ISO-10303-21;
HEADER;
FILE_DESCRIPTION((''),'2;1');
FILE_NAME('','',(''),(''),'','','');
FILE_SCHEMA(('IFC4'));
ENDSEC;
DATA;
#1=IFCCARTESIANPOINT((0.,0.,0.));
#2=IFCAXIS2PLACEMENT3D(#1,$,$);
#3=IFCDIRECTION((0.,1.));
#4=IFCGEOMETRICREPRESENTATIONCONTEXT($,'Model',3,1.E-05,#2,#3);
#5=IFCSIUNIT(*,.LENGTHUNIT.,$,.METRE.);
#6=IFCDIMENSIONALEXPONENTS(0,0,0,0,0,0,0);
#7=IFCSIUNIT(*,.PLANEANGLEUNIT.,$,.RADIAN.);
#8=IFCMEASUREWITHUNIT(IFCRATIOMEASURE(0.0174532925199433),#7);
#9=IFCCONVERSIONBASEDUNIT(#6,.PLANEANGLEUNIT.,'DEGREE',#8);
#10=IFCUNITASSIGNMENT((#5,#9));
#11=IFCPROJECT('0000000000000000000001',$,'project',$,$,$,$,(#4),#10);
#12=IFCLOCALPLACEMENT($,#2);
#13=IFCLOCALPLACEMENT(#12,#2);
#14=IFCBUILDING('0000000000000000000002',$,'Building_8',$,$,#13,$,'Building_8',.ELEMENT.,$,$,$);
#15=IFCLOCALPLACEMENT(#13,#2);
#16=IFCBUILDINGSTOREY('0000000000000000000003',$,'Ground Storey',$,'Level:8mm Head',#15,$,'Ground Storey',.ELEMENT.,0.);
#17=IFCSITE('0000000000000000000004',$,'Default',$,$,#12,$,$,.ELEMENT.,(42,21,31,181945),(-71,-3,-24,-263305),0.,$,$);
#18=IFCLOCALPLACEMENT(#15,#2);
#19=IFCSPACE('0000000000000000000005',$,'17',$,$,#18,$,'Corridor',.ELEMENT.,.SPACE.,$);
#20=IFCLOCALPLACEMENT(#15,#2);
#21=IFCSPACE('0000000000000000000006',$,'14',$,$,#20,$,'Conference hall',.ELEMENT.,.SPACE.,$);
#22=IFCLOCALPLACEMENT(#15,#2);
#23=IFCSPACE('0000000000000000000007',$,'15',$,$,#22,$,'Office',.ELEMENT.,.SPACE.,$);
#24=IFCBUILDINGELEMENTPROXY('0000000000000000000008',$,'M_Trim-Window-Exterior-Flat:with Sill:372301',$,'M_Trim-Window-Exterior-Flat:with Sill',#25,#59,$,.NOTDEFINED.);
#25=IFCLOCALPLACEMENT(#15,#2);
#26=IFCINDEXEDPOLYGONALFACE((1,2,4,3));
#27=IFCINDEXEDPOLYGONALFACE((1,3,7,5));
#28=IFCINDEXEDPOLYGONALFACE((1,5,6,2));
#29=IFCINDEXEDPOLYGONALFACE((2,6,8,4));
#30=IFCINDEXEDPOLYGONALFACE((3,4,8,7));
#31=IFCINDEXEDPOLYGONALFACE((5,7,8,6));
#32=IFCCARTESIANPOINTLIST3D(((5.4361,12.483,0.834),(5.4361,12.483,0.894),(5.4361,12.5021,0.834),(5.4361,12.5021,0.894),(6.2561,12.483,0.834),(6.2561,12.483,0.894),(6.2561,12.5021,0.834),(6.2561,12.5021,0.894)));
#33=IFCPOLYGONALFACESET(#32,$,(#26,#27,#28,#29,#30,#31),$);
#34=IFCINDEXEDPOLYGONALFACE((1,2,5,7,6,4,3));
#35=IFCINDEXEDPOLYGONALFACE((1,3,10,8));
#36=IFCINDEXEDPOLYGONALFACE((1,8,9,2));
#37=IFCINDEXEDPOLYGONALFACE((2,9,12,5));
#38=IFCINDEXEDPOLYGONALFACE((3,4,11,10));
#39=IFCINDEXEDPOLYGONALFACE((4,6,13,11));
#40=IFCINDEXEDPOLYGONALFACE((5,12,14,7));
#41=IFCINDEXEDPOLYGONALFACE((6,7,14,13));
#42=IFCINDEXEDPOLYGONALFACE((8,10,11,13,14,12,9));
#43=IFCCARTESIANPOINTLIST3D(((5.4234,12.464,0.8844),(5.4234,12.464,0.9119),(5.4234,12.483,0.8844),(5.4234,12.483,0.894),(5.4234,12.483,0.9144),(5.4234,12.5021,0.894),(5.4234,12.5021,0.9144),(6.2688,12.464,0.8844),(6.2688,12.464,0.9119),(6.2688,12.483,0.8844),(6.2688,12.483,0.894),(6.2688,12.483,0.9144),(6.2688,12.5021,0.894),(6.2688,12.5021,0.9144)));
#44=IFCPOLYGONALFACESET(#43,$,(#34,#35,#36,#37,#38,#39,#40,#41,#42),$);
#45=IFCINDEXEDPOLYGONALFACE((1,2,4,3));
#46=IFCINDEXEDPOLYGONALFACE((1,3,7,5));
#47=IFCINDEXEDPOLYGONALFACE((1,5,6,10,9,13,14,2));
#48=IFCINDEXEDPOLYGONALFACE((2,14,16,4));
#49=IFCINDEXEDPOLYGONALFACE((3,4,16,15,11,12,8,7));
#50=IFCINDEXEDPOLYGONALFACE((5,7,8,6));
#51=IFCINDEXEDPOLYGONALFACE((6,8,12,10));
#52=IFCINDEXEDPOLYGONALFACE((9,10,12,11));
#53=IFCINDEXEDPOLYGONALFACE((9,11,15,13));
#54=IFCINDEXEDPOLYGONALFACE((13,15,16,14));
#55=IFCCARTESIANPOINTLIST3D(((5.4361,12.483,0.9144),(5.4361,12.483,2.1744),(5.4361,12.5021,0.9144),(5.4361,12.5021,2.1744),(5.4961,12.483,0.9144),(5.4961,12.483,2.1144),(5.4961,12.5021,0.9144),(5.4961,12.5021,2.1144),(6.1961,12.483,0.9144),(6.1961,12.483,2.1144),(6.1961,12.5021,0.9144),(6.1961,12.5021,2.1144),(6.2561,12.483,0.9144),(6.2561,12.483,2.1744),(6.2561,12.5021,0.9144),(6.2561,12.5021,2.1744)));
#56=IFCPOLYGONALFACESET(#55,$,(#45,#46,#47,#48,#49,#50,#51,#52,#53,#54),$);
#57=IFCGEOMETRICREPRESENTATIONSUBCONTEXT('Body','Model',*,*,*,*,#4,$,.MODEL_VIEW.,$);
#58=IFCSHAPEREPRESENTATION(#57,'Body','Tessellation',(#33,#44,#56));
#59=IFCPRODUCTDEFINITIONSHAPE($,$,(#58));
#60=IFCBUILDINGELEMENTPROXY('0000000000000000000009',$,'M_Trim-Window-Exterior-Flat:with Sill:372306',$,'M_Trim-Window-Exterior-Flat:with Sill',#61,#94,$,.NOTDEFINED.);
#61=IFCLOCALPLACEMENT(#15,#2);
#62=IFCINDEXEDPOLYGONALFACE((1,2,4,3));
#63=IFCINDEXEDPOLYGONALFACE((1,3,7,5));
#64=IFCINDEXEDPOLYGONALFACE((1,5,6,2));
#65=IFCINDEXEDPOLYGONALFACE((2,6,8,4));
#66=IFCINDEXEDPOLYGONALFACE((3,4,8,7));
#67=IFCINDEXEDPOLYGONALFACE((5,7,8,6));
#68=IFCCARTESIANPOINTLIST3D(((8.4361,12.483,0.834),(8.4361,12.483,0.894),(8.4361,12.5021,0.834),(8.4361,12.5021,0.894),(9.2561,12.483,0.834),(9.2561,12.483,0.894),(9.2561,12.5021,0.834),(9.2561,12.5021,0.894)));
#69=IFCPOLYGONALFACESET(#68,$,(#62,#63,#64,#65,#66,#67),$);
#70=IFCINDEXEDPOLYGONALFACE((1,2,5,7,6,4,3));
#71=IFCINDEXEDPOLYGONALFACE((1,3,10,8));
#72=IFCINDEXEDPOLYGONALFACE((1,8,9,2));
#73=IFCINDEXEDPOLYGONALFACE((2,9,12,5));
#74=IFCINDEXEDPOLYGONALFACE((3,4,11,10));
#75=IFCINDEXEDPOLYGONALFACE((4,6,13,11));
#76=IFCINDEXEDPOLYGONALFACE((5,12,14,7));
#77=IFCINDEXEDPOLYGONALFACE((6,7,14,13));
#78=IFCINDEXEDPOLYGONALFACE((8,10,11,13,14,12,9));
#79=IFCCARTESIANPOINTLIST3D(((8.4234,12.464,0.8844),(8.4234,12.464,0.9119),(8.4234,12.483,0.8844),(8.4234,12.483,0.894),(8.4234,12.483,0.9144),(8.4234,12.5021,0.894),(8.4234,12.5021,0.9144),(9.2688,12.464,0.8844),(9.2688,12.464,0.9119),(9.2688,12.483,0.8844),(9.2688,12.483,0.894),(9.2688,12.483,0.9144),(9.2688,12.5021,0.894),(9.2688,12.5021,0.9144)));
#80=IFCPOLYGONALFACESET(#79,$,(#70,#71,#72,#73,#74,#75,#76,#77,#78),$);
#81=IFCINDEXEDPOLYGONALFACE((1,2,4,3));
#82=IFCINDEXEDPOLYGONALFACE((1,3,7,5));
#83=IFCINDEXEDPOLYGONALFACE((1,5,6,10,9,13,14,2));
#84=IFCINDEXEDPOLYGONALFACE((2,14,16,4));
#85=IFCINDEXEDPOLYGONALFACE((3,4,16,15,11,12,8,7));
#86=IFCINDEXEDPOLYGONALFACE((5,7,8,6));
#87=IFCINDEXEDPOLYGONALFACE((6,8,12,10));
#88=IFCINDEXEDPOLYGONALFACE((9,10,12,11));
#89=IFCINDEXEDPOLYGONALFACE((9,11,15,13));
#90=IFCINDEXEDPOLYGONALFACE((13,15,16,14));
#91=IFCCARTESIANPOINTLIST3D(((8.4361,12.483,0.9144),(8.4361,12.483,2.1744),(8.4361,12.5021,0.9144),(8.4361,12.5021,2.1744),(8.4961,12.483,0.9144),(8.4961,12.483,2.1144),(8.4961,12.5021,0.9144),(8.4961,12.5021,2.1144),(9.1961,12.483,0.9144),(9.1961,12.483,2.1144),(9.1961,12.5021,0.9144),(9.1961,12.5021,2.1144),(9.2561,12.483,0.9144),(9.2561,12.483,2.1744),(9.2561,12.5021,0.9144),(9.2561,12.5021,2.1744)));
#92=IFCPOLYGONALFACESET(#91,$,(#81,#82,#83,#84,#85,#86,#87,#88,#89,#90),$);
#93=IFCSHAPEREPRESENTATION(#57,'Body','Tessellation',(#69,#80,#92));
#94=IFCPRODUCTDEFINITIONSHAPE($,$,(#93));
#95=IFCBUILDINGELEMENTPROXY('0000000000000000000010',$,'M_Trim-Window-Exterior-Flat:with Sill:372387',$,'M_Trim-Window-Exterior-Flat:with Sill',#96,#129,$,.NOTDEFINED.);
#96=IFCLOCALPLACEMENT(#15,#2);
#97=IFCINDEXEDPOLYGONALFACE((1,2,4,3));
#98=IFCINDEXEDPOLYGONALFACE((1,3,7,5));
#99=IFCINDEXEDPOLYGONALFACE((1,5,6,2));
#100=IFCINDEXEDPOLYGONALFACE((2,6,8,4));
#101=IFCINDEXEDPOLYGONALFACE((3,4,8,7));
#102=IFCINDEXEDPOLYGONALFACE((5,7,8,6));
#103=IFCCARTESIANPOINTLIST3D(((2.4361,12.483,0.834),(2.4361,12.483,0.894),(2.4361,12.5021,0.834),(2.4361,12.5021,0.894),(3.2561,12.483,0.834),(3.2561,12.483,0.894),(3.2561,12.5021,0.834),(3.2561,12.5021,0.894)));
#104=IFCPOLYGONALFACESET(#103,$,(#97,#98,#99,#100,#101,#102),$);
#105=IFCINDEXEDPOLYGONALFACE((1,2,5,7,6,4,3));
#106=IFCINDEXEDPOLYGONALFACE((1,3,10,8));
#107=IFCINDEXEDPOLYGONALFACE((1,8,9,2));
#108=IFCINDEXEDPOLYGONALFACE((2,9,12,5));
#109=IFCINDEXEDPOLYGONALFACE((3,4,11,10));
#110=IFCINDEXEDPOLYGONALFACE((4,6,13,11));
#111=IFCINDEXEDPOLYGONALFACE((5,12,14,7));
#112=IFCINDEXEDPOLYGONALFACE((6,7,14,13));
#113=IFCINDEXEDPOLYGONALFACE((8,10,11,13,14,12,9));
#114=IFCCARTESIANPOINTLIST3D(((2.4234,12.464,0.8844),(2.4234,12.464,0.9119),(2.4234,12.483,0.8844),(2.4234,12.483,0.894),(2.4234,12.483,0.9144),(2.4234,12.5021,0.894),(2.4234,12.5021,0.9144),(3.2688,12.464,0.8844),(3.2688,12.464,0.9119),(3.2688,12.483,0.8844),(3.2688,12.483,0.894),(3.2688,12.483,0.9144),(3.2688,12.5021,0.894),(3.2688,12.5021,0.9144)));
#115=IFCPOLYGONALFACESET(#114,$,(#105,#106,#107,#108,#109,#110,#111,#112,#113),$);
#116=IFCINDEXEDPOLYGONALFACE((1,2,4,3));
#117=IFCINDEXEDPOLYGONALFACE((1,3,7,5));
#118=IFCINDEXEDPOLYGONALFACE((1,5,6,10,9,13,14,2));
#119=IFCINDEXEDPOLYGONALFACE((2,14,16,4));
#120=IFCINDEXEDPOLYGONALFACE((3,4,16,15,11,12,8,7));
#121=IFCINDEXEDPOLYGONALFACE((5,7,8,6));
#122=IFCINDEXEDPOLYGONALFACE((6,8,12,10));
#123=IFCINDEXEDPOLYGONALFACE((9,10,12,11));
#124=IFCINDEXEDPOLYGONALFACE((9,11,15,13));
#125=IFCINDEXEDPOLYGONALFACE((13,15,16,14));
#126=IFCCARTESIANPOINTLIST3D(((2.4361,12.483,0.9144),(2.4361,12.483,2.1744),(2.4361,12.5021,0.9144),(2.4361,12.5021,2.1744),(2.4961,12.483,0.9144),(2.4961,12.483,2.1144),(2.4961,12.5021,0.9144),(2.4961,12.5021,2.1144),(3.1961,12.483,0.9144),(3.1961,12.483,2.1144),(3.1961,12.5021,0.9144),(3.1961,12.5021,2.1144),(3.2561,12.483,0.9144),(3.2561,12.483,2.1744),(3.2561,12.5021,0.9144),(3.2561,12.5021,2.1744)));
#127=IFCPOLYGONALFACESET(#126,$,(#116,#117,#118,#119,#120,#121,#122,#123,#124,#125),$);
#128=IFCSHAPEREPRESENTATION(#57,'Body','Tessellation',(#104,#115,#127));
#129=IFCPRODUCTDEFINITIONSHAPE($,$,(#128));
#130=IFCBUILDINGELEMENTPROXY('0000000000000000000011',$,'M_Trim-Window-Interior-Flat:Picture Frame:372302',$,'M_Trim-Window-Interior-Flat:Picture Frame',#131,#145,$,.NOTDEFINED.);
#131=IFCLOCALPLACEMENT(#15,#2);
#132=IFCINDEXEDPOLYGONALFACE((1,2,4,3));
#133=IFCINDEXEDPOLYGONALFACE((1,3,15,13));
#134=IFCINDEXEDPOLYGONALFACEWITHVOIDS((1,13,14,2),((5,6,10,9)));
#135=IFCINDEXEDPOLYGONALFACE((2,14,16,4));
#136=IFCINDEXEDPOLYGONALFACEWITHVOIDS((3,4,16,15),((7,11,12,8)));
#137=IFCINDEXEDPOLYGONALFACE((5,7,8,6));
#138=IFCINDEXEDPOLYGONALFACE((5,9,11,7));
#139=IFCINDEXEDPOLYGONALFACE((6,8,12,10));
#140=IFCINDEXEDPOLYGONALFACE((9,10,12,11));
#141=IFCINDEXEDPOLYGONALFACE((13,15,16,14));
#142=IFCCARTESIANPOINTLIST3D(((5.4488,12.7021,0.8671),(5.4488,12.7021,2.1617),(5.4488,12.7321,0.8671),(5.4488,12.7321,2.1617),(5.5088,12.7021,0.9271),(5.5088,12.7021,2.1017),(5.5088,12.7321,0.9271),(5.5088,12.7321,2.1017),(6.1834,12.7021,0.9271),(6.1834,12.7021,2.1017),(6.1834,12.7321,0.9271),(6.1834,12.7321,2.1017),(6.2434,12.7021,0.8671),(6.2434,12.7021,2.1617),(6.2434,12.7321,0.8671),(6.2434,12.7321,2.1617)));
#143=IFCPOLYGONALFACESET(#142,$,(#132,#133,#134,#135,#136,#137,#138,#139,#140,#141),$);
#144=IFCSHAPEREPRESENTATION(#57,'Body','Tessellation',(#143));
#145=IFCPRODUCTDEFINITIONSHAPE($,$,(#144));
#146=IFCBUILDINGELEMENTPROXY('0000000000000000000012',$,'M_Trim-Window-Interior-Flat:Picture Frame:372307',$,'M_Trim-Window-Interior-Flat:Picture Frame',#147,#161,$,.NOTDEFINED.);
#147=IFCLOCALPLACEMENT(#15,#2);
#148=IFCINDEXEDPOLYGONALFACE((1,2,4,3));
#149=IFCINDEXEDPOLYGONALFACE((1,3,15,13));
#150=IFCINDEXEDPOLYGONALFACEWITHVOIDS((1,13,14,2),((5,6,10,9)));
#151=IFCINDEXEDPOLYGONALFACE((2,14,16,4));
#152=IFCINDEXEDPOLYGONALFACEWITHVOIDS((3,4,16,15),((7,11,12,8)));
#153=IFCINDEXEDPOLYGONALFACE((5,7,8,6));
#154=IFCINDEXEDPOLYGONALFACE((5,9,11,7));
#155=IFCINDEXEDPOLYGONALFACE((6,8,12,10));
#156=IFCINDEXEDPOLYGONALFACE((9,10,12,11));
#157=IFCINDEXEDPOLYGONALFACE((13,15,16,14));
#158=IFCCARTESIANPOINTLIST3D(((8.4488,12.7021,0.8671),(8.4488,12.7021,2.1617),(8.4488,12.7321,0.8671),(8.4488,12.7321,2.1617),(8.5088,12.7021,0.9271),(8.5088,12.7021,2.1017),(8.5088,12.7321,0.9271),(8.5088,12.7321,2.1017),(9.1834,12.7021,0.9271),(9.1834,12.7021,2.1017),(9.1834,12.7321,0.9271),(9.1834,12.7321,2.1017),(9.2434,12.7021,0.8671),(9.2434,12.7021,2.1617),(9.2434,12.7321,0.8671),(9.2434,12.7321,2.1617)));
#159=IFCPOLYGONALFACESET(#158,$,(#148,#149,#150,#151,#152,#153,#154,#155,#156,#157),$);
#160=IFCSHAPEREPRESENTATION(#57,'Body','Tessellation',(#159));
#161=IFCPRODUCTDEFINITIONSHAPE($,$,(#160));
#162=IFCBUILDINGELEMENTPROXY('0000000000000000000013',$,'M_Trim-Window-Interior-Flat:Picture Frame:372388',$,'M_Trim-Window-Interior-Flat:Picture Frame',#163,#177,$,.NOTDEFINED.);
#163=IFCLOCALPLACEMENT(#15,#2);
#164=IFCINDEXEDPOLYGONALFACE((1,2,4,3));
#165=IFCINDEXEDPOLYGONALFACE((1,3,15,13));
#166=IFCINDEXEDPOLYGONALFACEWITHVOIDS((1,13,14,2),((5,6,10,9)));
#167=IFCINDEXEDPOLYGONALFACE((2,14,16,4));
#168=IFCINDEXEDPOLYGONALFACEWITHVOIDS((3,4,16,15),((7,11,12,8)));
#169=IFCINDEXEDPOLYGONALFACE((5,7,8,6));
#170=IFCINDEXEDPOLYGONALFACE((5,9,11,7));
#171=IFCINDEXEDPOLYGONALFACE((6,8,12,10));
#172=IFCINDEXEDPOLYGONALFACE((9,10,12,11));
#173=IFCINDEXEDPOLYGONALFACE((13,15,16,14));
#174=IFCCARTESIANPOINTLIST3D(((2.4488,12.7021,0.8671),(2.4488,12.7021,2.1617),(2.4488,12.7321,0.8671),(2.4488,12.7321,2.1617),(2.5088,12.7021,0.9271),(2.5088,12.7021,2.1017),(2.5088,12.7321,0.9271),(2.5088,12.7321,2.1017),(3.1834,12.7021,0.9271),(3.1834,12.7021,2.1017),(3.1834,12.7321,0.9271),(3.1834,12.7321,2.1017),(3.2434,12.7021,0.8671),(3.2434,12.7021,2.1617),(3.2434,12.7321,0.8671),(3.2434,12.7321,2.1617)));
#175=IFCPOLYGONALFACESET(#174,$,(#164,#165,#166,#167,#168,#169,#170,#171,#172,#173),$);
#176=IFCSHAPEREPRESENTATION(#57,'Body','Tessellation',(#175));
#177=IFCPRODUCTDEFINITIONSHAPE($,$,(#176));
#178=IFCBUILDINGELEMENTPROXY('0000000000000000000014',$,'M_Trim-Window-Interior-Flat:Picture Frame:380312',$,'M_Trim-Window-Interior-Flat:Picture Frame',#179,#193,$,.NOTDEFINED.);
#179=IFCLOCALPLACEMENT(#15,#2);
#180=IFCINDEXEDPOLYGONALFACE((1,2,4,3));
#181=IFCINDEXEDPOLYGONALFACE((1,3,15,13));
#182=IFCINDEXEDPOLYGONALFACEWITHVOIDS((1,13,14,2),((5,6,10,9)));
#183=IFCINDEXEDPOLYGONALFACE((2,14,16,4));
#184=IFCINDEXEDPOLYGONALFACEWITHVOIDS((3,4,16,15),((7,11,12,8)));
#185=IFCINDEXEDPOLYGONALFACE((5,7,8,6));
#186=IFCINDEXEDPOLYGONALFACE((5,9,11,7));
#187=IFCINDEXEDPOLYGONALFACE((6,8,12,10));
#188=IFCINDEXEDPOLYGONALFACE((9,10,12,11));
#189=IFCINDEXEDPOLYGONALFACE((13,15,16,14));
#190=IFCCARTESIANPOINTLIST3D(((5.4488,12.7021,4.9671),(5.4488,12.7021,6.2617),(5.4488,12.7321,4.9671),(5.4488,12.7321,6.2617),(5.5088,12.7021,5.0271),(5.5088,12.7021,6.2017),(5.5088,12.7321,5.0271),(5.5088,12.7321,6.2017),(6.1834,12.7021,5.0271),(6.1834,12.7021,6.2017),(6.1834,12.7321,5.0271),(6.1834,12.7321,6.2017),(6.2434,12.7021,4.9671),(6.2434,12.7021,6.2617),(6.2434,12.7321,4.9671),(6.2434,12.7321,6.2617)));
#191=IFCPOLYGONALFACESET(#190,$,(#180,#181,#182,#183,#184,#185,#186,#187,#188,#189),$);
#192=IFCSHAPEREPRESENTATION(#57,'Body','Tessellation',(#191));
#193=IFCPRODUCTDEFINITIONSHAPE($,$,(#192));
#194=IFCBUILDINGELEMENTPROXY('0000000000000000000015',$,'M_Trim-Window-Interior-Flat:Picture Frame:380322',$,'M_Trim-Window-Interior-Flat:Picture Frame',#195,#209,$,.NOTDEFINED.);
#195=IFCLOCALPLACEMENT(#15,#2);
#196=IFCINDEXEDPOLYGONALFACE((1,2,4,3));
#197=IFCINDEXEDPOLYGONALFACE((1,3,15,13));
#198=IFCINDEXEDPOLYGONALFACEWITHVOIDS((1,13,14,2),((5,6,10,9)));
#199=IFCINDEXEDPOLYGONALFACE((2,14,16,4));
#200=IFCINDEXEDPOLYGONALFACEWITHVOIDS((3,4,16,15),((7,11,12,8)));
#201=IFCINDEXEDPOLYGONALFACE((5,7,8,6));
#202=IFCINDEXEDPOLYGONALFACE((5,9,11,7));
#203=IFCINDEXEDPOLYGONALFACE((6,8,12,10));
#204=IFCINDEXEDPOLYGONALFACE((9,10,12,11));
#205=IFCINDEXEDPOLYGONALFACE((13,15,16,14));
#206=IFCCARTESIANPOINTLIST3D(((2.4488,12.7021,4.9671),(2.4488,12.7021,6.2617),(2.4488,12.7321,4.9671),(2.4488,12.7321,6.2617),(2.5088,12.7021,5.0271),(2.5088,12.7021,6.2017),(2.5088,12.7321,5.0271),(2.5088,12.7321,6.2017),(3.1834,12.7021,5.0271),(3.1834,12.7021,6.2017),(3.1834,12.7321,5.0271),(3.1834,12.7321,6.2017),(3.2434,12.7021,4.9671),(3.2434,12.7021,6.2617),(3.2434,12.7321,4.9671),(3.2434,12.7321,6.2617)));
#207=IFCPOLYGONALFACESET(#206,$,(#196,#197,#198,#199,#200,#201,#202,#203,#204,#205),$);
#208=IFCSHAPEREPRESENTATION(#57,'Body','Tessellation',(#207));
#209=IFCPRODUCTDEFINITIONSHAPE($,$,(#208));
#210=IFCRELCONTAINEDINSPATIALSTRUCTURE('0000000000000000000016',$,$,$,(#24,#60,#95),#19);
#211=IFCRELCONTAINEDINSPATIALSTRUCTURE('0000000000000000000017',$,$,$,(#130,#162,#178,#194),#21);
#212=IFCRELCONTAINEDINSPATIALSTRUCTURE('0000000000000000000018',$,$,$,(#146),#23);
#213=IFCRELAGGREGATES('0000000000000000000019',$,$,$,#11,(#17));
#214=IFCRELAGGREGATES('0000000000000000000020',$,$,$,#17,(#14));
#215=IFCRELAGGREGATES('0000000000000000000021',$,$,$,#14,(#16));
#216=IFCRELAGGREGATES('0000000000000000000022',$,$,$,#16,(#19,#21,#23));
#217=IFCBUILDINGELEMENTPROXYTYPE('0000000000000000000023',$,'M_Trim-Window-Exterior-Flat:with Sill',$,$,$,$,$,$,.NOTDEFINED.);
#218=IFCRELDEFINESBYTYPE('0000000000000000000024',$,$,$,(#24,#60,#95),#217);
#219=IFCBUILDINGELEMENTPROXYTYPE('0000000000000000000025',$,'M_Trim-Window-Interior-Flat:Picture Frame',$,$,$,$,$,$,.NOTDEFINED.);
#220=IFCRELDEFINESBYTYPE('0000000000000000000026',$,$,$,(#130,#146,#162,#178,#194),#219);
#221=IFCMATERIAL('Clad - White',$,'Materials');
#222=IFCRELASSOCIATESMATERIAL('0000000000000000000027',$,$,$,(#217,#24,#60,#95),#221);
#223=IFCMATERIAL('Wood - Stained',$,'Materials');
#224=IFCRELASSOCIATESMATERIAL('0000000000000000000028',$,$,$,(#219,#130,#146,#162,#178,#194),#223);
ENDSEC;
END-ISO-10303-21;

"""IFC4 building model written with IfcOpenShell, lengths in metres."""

from ifc_helpers import new_model, entity, si_unit, converted_unit, direction, frame, origin, place, context, subcontext, project, spatial, indexed_curve, outline, extrude, source, transform, mapped, material, type_object, type_shapes, element, save


model = new_model("IFC4")

# Units and contexts
model_context = context("Model", 3, precision=1e-05, world=origin(), true_north=direction((0.0, 1.0)))
body_context = subcontext(model_context, "Body", "Model", "MODEL_VIEW")
ifc_project = project(units=[si_unit("LENGTHUNIT", "METRE"), converted_unit("PLANEANGLEUNIT", "DEGREE", entity("IfcRatioMeasure", 0.0174532925199433), si_unit("PLANEANGLEUNIT", "RADIAN"), dimensions=[0, 0, 0, 0, 0, 0, 0])], contexts=[model_context])

# Site, building, storey
site_placement = place(None, origin())
site = spatial("IfcSite", under=ifc_project, at=site_placement, Name="Default", CompositionType="ELEMENT", RefLatitude=(42, 21, 31, 181945), RefLongitude=(-71, -3, -24, -263305), RefElevation=0.0)
building_placement = place(site_placement, origin())
building = spatial("IfcBuilding", under=site, at=building_placement, Name="Building_8", LongName="Building_8", CompositionType="ELEMENT")
storey_placement = place(building_placement, origin())
storey = spatial("IfcBuildingStorey", under=building, at=storey_placement, Name="Ground Storey", ObjectType="Level:8mm Head", LongName="Ground Storey", CompositionType="ELEMENT", Elevation=0.0)

# Shared definitions
ifc_material_1 = material(Name="Clad - White", Category="Materials")
ifc_material_2 = material(Name="Wood - Stained", Category="Materials")

# Shared definitions
space_1_placement = place(storey_placement, origin())
space_1 = spatial("IfcSpace", under=storey, at=space_1_placement, Name="17", LongName="Corridor", CompositionType="ELEMENT", PredefinedType="SPACE")

# Building element proxies
building_element_proxy_type_1 = type_object("IfcBuildingElementProxyType", Name="M_Trim-Window-Exterior-Flat:with Sill", PredefinedType="NOTDEFINED", material=ifc_material_1)
shared_shape_1 = source(origin(), body_context, "Body", "SweptSolid", [
    extrude(outline(indexed_curve([(-0.03, -0.41), (0.03, -0.41), (0.03, 0.41), (-0.03, 0.41), (-0.03, -0.41)], self_intersect=False)), frame((0.0, 1.2504, 0.0), z_axis=(0.0, 0.0, 1.0), x_axis=(0.0, 1.0, 0.0)), (0.0, 0.0, 1.0), 0.0191),
    extrude(outline(indexed_curve([(-0.0152, -0.019), (0.0123, -0.019), (0.0148, 0.0), (0.0148, 0.019), (-0.0057, 0.019), (-0.0057, 0.0), (-0.0152, 0.0), (-0.0152, -0.019)], self_intersect=False)), frame((-0.4227, 1.2148, 0.019), z_axis=(1.0, 0.0, 0.0), x_axis=(0.0, -1.0, 0.0)), (0.0, 0.0, 1.0), 0.8454),
    extrude(outline(indexed_curve([(-0.41, -0.645), (0.41, -0.645), (0.41, 0.615), (0.35, 0.615), (0.35, -0.585), (-0.35, -0.585), (-0.35, 0.615), (-0.41, 0.615), (-0.41, -0.645)], self_intersect=False)), frame((0.0, 0.585, 0.0)), (0.0, 0.0, 1.0), 0.0191),
])
type_shapes(building_element_proxy_type_1, [shared_shape_1])
for number, where, z_axis, x_axis, name in (
    (1, (5.8461, 12.5021, 2.1144), (0.0, -1.0, 0.0), (-1.0, 0.0, 0.0), "M_Trim-Window-Exterior-Flat:with Sill:372301"),
    (2, (8.8461, 12.5021, 2.1144), (0.0, -1.0, 0.0), (-1.0, 0.0, 0.0), "M_Trim-Window-Exterior-Flat:with Sill:372306"),
    (3, (2.8461, 12.5021, 2.1144), (0.0, -1.0, 0.0), (-1.0, 0.0, 0.0), "M_Trim-Window-Exterior-Flat:with Sill:372387"),
):
    element("IfcBuildingElementProxy", number, at=place(space_1_placement, frame(where, z_axis=z_axis, x_axis=x_axis)), inside=space_1, type_object=building_element_proxy_type_1, material=ifc_material_1, Name=name, ObjectType="M_Trim-Window-Exterior-Flat:with Sill", PredefinedType="NOTDEFINED", context=body_context, shape_type="MappedRepresentation", body=[
        mapped(shared_shape_1, transform((0.0, 0.0, 0.0), scale=1.0)),
    ])

# Shared definitions
space_2_placement = place(storey_placement, origin())
space_2 = spatial("IfcSpace", under=storey, at=space_2_placement, Name="14", LongName="Conference hall", CompositionType="ELEMENT", PredefinedType="SPACE")

# Building element proxy
building_element_proxy_type_2 = type_object("IfcBuildingElementProxyType", Name="M_Trim-Window-Interior-Flat:Picture Frame", PredefinedType="NOTDEFINED", material=ifc_material_2)
shared_shape_2 = source(origin(), body_context, "Body", "SweptSolid", [
    extrude(outline(indexed_curve([(-0.6473, -0.3973), (0.6473, -0.3973), (0.6473, 0.3973), (-0.6473, 0.3973), (-0.6473, -0.3973)], self_intersect=False), holes=[indexed_curve([(-0.5873, -0.3373), (-0.5873, 0.3373), (0.5873, 0.3373), (0.5873, -0.3373), (-0.5873, -0.3373)], self_intersect=False)]), frame((0.0, 0.6, 0.0), z_axis=(0.0, 0.0, 1.0), x_axis=(0.0, 1.0, 0.0)), (0.0, 0.0, 1.0), 0.03),
])
type_shapes(building_element_proxy_type_2, [shared_shape_2])
proxy_1_placement = place(space_2_placement, frame((5.8461, 12.7021, 2.1144), z_axis=(0.0, 1.0, 0.0), x_axis=(1.0, 0.0, 0.0)))
element("IfcBuildingElementProxy", 4, at=proxy_1_placement, inside=space_2, type_object=building_element_proxy_type_2, material=ifc_material_2, Name="M_Trim-Window-Interior-Flat:Picture Frame:372302", ObjectType="M_Trim-Window-Interior-Flat:Picture Frame", PredefinedType="NOTDEFINED", context=body_context, shape_type="MappedRepresentation", body=[
    mapped(shared_shape_2, transform((0.0, 0.0, 0.0), scale=1.0)),
])

# Shared definitions
space_3_placement = place(storey_placement, origin())
space_3 = spatial("IfcSpace", under=storey, at=space_3_placement, Name="15", LongName="Office", CompositionType="ELEMENT", PredefinedType="SPACE")

# Building element proxies
proxy_2_placement = place(space_3_placement, frame((8.8461, 12.7021, 2.1144), z_axis=(0.0, 1.0, 0.0), x_axis=(1.0, 0.0, 0.0)))
element("IfcBuildingElementProxy", 5, at=proxy_2_placement, inside=space_3, type_object=building_element_proxy_type_2, material=ifc_material_2, Name="M_Trim-Window-Interior-Flat:Picture Frame:372307", ObjectType="M_Trim-Window-Interior-Flat:Picture Frame", PredefinedType="NOTDEFINED", context=body_context, shape_type="MappedRepresentation", body=[
    mapped(shared_shape_2, transform((0.0, 0.0, 0.0), scale=1.0)),
])
for number, where, z_axis, x_axis, name in (
    (6, (2.8461, 12.7021, 2.1144), (0.0, 1.0, 0.0), (1.0, 0.0, 0.0), "M_Trim-Window-Interior-Flat:Picture Frame:372388"),
    (7, (5.8461, 12.7021, 6.2144), (0.0, 1.0, 0.0), (1.0, 0.0, 0.0), "M_Trim-Window-Interior-Flat:Picture Frame:380312"),
    (8, (2.8461, 12.7021, 6.2144), (0.0, 1.0, 0.0), (1.0, 0.0, 0.0), "M_Trim-Window-Interior-Flat:Picture Frame:380322"),
):
    element("IfcBuildingElementProxy", number, at=place(space_2_placement, frame(where, z_axis=z_axis, x_axis=x_axis)), inside=space_2, type_object=building_element_proxy_type_2, material=ifc_material_2, Name=name, ObjectType="M_Trim-Window-Interior-Flat:Picture Frame", PredefinedType="NOTDEFINED", context=body_context, shape_type="MappedRepresentation", body=[
        mapped(shared_shape_2, transform((0.0, 0.0, 0.0), scale=1.0)),
    ])

save(model, "model.ifc")
